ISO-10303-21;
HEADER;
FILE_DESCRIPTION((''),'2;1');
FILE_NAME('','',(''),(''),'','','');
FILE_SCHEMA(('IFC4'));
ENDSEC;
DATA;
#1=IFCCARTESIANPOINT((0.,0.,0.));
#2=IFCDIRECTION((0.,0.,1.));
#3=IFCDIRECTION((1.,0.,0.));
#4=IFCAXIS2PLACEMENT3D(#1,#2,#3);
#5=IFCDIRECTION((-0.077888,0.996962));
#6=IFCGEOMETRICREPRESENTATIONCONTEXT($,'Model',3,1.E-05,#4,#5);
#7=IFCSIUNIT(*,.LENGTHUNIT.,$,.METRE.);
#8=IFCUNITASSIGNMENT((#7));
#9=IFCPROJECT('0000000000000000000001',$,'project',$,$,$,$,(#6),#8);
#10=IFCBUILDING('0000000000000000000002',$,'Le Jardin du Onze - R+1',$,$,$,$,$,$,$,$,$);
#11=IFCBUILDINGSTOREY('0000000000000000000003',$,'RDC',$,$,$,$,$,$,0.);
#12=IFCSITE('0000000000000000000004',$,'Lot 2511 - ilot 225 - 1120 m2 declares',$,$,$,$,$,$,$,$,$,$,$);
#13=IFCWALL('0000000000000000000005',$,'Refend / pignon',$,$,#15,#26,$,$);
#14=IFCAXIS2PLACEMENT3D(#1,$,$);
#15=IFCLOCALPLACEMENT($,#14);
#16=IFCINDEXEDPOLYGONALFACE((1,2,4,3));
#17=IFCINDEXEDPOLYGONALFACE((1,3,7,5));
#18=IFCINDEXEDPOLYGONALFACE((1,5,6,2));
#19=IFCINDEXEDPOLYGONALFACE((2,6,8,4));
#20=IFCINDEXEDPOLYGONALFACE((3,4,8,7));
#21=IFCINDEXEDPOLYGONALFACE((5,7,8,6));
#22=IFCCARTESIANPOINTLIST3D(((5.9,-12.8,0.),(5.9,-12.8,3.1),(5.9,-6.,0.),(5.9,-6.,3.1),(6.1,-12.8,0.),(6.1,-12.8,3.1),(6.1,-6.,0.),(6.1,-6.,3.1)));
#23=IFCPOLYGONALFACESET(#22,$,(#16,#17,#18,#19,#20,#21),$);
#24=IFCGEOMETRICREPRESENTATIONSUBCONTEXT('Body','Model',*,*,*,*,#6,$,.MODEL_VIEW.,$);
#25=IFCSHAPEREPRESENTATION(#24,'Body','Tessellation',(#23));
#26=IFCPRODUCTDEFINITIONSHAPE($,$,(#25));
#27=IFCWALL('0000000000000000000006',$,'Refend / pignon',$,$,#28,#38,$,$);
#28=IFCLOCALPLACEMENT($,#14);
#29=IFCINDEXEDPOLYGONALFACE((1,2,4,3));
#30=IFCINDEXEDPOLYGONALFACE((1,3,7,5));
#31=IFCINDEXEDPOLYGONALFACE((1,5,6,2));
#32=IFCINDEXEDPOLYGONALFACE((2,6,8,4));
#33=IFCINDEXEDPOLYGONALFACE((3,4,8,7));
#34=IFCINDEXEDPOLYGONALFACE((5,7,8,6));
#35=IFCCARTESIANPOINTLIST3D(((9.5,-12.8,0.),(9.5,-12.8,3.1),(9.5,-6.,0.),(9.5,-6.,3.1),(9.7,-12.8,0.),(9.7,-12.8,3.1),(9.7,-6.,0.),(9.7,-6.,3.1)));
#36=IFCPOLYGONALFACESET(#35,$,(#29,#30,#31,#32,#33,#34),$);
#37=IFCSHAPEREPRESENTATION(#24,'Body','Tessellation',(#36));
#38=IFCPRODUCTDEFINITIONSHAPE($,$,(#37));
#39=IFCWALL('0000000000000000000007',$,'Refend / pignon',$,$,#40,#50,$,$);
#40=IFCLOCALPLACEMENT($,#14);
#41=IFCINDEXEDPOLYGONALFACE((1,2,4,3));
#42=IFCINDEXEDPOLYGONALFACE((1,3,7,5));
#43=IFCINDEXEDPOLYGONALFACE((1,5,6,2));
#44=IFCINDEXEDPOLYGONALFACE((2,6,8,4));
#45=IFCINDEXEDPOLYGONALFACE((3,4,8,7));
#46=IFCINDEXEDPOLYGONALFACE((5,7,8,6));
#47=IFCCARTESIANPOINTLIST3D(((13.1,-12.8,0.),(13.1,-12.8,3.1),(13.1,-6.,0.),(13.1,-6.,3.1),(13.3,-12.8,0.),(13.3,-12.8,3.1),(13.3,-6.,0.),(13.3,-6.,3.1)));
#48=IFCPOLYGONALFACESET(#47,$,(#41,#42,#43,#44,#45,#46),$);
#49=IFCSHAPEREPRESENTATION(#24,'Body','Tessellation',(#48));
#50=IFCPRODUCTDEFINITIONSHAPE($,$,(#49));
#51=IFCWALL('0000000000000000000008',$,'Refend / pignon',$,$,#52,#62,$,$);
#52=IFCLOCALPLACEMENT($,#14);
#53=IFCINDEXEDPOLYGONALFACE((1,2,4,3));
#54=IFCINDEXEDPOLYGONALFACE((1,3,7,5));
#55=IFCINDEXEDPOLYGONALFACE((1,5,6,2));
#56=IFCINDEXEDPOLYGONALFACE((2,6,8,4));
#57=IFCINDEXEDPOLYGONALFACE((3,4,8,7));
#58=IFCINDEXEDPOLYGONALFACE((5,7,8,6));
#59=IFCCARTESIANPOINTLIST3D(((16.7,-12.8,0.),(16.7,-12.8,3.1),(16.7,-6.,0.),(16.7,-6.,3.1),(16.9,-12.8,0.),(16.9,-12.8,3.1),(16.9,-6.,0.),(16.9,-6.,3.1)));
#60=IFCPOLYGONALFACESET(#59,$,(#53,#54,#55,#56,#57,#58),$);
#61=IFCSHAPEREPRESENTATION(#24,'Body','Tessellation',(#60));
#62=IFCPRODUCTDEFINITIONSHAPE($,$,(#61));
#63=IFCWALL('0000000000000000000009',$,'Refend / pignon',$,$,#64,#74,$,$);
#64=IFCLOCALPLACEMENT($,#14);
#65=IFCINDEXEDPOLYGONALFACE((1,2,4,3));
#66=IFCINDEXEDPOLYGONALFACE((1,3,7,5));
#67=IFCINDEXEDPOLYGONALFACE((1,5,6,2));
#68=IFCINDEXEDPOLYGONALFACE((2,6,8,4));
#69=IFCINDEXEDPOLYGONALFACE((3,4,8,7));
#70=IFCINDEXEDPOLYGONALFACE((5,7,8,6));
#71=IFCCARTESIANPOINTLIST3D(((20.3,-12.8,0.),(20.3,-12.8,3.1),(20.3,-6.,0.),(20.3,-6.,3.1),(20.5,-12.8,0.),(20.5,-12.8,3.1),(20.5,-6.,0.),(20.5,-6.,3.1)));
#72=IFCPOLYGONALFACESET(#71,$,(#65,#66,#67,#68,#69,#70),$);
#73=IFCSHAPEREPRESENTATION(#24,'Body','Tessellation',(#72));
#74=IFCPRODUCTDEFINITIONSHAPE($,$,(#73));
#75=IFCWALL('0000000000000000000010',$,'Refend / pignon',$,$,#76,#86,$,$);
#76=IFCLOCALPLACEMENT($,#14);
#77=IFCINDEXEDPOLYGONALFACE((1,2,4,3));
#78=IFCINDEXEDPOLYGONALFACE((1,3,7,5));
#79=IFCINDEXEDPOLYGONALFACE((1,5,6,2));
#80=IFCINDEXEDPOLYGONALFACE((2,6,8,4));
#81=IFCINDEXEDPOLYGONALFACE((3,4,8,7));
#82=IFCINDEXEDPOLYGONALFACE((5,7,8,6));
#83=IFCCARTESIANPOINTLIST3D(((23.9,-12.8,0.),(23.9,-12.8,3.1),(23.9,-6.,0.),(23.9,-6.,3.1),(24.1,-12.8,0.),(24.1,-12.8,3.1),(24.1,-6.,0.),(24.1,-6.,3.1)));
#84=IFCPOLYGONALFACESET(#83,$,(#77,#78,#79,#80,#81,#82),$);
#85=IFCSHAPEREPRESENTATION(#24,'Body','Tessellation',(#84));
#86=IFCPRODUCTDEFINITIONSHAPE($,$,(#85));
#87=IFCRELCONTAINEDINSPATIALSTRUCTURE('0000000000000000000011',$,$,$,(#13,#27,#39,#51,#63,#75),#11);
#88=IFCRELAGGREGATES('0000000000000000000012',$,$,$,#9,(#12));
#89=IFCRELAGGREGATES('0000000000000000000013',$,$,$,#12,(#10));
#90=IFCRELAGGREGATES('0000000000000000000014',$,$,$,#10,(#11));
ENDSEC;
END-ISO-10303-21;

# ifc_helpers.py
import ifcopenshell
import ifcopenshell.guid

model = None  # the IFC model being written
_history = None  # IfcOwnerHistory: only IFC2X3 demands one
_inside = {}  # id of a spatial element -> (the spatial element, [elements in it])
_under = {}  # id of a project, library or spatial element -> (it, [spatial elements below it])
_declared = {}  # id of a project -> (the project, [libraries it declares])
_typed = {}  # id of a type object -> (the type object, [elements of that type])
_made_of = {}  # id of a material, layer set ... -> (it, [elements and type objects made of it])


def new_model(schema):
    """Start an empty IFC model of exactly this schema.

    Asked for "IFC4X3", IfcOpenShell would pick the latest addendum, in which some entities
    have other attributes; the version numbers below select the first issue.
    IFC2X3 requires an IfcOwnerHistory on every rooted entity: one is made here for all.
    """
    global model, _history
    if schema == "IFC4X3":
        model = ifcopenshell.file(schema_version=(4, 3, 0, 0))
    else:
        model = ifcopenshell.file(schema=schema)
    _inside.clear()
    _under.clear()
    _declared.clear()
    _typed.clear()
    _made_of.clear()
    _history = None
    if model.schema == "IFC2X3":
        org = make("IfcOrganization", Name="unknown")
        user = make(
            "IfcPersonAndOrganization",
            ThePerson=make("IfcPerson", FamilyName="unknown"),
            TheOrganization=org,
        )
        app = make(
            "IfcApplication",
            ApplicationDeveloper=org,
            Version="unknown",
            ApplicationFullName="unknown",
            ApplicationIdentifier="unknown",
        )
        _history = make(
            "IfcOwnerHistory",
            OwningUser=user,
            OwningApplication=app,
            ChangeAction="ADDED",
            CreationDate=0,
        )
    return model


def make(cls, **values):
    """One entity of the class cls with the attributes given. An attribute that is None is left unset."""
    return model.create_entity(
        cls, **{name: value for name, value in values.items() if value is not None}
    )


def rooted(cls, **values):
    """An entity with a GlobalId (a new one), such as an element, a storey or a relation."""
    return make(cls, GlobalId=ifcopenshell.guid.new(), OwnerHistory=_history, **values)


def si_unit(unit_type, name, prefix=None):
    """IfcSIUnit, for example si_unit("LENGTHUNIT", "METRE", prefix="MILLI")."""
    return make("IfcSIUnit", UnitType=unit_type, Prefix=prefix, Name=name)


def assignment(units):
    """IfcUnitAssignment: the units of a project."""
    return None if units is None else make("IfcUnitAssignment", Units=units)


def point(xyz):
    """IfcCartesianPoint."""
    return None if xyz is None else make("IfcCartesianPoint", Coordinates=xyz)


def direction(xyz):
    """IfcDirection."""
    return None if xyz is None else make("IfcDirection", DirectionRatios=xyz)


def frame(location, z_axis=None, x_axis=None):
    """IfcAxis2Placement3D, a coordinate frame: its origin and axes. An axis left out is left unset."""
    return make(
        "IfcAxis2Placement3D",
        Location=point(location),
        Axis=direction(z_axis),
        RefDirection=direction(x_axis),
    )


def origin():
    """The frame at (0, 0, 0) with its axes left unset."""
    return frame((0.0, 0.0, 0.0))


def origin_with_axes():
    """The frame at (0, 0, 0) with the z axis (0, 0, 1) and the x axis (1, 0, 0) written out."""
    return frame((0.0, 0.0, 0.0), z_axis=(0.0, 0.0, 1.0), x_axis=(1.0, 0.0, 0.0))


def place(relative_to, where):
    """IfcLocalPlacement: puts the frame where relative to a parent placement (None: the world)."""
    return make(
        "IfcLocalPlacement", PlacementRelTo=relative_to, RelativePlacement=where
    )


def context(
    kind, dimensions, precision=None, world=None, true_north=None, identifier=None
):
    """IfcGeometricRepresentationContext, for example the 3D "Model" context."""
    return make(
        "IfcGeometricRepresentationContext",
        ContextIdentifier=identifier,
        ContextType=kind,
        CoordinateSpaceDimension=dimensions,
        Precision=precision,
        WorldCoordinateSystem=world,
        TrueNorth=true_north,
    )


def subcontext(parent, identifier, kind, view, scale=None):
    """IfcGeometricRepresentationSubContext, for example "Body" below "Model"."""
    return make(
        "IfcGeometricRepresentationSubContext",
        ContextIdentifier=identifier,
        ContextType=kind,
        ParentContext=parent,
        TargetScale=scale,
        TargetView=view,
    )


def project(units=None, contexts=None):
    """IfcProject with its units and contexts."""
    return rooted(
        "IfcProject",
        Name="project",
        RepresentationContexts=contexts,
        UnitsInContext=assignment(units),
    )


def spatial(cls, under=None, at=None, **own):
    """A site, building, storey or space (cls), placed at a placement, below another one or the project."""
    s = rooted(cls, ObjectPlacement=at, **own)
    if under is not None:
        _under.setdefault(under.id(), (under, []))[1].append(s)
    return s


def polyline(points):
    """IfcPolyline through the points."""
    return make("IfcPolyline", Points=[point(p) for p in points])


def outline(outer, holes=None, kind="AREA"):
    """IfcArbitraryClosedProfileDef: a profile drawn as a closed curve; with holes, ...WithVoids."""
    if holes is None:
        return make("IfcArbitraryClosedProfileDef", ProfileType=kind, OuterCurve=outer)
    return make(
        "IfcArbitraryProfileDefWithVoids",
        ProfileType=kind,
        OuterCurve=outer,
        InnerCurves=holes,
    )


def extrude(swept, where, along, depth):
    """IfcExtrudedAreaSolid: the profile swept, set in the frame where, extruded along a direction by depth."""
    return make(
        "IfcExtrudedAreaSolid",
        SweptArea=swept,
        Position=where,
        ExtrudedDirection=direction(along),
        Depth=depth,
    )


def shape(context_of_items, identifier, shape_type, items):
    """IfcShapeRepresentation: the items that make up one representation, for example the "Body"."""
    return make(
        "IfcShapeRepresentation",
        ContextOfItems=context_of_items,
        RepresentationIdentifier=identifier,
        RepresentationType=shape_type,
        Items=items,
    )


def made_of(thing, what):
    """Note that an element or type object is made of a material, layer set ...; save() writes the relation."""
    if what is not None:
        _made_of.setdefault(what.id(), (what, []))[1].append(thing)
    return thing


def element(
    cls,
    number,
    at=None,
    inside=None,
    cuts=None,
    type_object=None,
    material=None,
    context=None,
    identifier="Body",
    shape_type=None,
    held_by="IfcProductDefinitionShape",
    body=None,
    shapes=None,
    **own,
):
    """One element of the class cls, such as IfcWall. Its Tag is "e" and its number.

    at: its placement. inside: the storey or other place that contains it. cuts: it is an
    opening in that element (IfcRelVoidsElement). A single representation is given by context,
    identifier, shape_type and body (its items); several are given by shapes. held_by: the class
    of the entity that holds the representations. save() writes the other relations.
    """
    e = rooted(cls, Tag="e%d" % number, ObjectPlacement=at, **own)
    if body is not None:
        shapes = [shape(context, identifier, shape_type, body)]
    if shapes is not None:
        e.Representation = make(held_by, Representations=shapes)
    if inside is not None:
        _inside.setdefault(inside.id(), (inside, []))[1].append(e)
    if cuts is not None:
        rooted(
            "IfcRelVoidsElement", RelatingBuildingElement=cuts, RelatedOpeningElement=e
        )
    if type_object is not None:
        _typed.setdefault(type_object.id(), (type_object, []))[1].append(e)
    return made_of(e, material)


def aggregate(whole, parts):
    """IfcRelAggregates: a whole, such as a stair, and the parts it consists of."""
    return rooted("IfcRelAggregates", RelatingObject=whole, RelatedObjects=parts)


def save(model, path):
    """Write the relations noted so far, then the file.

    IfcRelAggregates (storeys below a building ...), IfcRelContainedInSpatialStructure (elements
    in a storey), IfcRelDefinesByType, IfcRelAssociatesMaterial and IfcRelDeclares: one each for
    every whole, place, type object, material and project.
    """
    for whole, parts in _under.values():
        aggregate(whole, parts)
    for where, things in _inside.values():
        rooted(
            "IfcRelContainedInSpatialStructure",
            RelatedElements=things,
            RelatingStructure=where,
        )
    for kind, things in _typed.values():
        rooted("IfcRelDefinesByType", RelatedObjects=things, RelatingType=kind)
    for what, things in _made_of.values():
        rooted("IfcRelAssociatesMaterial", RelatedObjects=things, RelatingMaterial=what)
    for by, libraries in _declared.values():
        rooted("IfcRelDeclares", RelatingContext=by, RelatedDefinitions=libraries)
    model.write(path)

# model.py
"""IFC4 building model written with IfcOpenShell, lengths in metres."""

from ifc_helpers import new_model, si_unit, direction, origin, origin_with_axes, place, context, subcontext, project, spatial, polyline, outline, extrude, element, save


model = new_model("IFC4")

# Units and contexts
model_context = context("Model", 3, precision=1e-05, world=origin_with_axes(), true_north=direction((-0.077888, 0.996962)))
body_context = subcontext(model_context, "Body", "Model", "MODEL_VIEW")
ifc_project = project(units=[si_unit("LENGTHUNIT", "METRE")], contexts=[model_context])

# Site, building, storey
site = spatial("IfcSite", under=ifc_project, Name="Lot 2511 - ilot 225 - 1120 m2 declares")
building = spatial("IfcBuilding", under=site, Name="Le Jardin du Onze - R+1")
storey = spatial("IfcBuildingStorey", under=building, Name="RDC", Elevation=0.0)

# Walls
wall_1_placement = place(None, origin_with_axes())
element("IfcWall", 1, at=wall_1_placement, inside=storey, Name="Refend / pignon", context=body_context, shape_type="SweptSolid", body=[
    extrude(outline(polyline([(6.1, -12.8), (6.1, -6.0), (5.9, -6.0), (5.9, -12.8), (6.1, -12.8)])), origin(), (0.0, 0.0, 1.0), 3.1),
])
wall_2_placement = place(None, origin_with_axes())
element("IfcWall", 2, at=wall_2_placement, inside=storey, Name="Refend / pignon", context=body_context, shape_type="SweptSolid", body=[
    extrude(outline(polyline([(9.7, -12.8), (9.7, -6.0), (9.5, -6.0), (9.5, -12.8), (9.7, -12.8)])), origin(), (0.0, 0.0, 1.0), 3.1),
])
wall_3_placement = place(None, origin_with_axes())
element("IfcWall", 3, at=wall_3_placement, inside=storey, Name="Refend / pignon", context=body_context, shape_type="SweptSolid", body=[
    extrude(outline(polyline([(13.3, -12.8), (13.3, -6.0), (13.1, -6.0), (13.1, -12.8), (13.3, -12.8)])), origin(), (0.0, 0.0, 1.0), 3.1),
])
wall_4_placement = place(None, origin_with_axes())
element("IfcWall", 4, at=wall_4_placement, inside=storey, Name="Refend / pignon", context=body_context, shape_type="SweptSolid", body=[
    extrude(outline(polyline([(16.9, -12.8), (16.9, -6.0), (16.7, -6.0), (16.7, -12.8), (16.9, -12.8)])), origin(), (0.0, 0.0, 1.0), 3.1),
])
wall_5_placement = place(None, origin_with_axes())
element("IfcWall", 5, at=wall_5_placement, inside=storey, Name="Refend / pignon", context=body_context, shape_type="SweptSolid", body=[
    extrude(outline(polyline([(20.5, -12.8), (20.5, -6.0), (20.3, -6.0), (20.3, -12.8), (20.5, -12.8)])), origin(), (0.0, 0.0, 1.0), 3.1),
])
wall_6_placement = place(None, origin_with_axes())
element("IfcWall", 6, at=wall_6_placement, inside=storey, Name="Refend / pignon", context=body_context, shape_type="SweptSolid", body=[
    extrude(outline(polyline([(24.1, -12.8), (24.1, -6.0), (23.9, -6.0), (23.9, -12.8), (24.1, -12.8)])), origin(), (0.0, 0.0, 1.0), 3.1),
])

save(model, "model.ifc")
